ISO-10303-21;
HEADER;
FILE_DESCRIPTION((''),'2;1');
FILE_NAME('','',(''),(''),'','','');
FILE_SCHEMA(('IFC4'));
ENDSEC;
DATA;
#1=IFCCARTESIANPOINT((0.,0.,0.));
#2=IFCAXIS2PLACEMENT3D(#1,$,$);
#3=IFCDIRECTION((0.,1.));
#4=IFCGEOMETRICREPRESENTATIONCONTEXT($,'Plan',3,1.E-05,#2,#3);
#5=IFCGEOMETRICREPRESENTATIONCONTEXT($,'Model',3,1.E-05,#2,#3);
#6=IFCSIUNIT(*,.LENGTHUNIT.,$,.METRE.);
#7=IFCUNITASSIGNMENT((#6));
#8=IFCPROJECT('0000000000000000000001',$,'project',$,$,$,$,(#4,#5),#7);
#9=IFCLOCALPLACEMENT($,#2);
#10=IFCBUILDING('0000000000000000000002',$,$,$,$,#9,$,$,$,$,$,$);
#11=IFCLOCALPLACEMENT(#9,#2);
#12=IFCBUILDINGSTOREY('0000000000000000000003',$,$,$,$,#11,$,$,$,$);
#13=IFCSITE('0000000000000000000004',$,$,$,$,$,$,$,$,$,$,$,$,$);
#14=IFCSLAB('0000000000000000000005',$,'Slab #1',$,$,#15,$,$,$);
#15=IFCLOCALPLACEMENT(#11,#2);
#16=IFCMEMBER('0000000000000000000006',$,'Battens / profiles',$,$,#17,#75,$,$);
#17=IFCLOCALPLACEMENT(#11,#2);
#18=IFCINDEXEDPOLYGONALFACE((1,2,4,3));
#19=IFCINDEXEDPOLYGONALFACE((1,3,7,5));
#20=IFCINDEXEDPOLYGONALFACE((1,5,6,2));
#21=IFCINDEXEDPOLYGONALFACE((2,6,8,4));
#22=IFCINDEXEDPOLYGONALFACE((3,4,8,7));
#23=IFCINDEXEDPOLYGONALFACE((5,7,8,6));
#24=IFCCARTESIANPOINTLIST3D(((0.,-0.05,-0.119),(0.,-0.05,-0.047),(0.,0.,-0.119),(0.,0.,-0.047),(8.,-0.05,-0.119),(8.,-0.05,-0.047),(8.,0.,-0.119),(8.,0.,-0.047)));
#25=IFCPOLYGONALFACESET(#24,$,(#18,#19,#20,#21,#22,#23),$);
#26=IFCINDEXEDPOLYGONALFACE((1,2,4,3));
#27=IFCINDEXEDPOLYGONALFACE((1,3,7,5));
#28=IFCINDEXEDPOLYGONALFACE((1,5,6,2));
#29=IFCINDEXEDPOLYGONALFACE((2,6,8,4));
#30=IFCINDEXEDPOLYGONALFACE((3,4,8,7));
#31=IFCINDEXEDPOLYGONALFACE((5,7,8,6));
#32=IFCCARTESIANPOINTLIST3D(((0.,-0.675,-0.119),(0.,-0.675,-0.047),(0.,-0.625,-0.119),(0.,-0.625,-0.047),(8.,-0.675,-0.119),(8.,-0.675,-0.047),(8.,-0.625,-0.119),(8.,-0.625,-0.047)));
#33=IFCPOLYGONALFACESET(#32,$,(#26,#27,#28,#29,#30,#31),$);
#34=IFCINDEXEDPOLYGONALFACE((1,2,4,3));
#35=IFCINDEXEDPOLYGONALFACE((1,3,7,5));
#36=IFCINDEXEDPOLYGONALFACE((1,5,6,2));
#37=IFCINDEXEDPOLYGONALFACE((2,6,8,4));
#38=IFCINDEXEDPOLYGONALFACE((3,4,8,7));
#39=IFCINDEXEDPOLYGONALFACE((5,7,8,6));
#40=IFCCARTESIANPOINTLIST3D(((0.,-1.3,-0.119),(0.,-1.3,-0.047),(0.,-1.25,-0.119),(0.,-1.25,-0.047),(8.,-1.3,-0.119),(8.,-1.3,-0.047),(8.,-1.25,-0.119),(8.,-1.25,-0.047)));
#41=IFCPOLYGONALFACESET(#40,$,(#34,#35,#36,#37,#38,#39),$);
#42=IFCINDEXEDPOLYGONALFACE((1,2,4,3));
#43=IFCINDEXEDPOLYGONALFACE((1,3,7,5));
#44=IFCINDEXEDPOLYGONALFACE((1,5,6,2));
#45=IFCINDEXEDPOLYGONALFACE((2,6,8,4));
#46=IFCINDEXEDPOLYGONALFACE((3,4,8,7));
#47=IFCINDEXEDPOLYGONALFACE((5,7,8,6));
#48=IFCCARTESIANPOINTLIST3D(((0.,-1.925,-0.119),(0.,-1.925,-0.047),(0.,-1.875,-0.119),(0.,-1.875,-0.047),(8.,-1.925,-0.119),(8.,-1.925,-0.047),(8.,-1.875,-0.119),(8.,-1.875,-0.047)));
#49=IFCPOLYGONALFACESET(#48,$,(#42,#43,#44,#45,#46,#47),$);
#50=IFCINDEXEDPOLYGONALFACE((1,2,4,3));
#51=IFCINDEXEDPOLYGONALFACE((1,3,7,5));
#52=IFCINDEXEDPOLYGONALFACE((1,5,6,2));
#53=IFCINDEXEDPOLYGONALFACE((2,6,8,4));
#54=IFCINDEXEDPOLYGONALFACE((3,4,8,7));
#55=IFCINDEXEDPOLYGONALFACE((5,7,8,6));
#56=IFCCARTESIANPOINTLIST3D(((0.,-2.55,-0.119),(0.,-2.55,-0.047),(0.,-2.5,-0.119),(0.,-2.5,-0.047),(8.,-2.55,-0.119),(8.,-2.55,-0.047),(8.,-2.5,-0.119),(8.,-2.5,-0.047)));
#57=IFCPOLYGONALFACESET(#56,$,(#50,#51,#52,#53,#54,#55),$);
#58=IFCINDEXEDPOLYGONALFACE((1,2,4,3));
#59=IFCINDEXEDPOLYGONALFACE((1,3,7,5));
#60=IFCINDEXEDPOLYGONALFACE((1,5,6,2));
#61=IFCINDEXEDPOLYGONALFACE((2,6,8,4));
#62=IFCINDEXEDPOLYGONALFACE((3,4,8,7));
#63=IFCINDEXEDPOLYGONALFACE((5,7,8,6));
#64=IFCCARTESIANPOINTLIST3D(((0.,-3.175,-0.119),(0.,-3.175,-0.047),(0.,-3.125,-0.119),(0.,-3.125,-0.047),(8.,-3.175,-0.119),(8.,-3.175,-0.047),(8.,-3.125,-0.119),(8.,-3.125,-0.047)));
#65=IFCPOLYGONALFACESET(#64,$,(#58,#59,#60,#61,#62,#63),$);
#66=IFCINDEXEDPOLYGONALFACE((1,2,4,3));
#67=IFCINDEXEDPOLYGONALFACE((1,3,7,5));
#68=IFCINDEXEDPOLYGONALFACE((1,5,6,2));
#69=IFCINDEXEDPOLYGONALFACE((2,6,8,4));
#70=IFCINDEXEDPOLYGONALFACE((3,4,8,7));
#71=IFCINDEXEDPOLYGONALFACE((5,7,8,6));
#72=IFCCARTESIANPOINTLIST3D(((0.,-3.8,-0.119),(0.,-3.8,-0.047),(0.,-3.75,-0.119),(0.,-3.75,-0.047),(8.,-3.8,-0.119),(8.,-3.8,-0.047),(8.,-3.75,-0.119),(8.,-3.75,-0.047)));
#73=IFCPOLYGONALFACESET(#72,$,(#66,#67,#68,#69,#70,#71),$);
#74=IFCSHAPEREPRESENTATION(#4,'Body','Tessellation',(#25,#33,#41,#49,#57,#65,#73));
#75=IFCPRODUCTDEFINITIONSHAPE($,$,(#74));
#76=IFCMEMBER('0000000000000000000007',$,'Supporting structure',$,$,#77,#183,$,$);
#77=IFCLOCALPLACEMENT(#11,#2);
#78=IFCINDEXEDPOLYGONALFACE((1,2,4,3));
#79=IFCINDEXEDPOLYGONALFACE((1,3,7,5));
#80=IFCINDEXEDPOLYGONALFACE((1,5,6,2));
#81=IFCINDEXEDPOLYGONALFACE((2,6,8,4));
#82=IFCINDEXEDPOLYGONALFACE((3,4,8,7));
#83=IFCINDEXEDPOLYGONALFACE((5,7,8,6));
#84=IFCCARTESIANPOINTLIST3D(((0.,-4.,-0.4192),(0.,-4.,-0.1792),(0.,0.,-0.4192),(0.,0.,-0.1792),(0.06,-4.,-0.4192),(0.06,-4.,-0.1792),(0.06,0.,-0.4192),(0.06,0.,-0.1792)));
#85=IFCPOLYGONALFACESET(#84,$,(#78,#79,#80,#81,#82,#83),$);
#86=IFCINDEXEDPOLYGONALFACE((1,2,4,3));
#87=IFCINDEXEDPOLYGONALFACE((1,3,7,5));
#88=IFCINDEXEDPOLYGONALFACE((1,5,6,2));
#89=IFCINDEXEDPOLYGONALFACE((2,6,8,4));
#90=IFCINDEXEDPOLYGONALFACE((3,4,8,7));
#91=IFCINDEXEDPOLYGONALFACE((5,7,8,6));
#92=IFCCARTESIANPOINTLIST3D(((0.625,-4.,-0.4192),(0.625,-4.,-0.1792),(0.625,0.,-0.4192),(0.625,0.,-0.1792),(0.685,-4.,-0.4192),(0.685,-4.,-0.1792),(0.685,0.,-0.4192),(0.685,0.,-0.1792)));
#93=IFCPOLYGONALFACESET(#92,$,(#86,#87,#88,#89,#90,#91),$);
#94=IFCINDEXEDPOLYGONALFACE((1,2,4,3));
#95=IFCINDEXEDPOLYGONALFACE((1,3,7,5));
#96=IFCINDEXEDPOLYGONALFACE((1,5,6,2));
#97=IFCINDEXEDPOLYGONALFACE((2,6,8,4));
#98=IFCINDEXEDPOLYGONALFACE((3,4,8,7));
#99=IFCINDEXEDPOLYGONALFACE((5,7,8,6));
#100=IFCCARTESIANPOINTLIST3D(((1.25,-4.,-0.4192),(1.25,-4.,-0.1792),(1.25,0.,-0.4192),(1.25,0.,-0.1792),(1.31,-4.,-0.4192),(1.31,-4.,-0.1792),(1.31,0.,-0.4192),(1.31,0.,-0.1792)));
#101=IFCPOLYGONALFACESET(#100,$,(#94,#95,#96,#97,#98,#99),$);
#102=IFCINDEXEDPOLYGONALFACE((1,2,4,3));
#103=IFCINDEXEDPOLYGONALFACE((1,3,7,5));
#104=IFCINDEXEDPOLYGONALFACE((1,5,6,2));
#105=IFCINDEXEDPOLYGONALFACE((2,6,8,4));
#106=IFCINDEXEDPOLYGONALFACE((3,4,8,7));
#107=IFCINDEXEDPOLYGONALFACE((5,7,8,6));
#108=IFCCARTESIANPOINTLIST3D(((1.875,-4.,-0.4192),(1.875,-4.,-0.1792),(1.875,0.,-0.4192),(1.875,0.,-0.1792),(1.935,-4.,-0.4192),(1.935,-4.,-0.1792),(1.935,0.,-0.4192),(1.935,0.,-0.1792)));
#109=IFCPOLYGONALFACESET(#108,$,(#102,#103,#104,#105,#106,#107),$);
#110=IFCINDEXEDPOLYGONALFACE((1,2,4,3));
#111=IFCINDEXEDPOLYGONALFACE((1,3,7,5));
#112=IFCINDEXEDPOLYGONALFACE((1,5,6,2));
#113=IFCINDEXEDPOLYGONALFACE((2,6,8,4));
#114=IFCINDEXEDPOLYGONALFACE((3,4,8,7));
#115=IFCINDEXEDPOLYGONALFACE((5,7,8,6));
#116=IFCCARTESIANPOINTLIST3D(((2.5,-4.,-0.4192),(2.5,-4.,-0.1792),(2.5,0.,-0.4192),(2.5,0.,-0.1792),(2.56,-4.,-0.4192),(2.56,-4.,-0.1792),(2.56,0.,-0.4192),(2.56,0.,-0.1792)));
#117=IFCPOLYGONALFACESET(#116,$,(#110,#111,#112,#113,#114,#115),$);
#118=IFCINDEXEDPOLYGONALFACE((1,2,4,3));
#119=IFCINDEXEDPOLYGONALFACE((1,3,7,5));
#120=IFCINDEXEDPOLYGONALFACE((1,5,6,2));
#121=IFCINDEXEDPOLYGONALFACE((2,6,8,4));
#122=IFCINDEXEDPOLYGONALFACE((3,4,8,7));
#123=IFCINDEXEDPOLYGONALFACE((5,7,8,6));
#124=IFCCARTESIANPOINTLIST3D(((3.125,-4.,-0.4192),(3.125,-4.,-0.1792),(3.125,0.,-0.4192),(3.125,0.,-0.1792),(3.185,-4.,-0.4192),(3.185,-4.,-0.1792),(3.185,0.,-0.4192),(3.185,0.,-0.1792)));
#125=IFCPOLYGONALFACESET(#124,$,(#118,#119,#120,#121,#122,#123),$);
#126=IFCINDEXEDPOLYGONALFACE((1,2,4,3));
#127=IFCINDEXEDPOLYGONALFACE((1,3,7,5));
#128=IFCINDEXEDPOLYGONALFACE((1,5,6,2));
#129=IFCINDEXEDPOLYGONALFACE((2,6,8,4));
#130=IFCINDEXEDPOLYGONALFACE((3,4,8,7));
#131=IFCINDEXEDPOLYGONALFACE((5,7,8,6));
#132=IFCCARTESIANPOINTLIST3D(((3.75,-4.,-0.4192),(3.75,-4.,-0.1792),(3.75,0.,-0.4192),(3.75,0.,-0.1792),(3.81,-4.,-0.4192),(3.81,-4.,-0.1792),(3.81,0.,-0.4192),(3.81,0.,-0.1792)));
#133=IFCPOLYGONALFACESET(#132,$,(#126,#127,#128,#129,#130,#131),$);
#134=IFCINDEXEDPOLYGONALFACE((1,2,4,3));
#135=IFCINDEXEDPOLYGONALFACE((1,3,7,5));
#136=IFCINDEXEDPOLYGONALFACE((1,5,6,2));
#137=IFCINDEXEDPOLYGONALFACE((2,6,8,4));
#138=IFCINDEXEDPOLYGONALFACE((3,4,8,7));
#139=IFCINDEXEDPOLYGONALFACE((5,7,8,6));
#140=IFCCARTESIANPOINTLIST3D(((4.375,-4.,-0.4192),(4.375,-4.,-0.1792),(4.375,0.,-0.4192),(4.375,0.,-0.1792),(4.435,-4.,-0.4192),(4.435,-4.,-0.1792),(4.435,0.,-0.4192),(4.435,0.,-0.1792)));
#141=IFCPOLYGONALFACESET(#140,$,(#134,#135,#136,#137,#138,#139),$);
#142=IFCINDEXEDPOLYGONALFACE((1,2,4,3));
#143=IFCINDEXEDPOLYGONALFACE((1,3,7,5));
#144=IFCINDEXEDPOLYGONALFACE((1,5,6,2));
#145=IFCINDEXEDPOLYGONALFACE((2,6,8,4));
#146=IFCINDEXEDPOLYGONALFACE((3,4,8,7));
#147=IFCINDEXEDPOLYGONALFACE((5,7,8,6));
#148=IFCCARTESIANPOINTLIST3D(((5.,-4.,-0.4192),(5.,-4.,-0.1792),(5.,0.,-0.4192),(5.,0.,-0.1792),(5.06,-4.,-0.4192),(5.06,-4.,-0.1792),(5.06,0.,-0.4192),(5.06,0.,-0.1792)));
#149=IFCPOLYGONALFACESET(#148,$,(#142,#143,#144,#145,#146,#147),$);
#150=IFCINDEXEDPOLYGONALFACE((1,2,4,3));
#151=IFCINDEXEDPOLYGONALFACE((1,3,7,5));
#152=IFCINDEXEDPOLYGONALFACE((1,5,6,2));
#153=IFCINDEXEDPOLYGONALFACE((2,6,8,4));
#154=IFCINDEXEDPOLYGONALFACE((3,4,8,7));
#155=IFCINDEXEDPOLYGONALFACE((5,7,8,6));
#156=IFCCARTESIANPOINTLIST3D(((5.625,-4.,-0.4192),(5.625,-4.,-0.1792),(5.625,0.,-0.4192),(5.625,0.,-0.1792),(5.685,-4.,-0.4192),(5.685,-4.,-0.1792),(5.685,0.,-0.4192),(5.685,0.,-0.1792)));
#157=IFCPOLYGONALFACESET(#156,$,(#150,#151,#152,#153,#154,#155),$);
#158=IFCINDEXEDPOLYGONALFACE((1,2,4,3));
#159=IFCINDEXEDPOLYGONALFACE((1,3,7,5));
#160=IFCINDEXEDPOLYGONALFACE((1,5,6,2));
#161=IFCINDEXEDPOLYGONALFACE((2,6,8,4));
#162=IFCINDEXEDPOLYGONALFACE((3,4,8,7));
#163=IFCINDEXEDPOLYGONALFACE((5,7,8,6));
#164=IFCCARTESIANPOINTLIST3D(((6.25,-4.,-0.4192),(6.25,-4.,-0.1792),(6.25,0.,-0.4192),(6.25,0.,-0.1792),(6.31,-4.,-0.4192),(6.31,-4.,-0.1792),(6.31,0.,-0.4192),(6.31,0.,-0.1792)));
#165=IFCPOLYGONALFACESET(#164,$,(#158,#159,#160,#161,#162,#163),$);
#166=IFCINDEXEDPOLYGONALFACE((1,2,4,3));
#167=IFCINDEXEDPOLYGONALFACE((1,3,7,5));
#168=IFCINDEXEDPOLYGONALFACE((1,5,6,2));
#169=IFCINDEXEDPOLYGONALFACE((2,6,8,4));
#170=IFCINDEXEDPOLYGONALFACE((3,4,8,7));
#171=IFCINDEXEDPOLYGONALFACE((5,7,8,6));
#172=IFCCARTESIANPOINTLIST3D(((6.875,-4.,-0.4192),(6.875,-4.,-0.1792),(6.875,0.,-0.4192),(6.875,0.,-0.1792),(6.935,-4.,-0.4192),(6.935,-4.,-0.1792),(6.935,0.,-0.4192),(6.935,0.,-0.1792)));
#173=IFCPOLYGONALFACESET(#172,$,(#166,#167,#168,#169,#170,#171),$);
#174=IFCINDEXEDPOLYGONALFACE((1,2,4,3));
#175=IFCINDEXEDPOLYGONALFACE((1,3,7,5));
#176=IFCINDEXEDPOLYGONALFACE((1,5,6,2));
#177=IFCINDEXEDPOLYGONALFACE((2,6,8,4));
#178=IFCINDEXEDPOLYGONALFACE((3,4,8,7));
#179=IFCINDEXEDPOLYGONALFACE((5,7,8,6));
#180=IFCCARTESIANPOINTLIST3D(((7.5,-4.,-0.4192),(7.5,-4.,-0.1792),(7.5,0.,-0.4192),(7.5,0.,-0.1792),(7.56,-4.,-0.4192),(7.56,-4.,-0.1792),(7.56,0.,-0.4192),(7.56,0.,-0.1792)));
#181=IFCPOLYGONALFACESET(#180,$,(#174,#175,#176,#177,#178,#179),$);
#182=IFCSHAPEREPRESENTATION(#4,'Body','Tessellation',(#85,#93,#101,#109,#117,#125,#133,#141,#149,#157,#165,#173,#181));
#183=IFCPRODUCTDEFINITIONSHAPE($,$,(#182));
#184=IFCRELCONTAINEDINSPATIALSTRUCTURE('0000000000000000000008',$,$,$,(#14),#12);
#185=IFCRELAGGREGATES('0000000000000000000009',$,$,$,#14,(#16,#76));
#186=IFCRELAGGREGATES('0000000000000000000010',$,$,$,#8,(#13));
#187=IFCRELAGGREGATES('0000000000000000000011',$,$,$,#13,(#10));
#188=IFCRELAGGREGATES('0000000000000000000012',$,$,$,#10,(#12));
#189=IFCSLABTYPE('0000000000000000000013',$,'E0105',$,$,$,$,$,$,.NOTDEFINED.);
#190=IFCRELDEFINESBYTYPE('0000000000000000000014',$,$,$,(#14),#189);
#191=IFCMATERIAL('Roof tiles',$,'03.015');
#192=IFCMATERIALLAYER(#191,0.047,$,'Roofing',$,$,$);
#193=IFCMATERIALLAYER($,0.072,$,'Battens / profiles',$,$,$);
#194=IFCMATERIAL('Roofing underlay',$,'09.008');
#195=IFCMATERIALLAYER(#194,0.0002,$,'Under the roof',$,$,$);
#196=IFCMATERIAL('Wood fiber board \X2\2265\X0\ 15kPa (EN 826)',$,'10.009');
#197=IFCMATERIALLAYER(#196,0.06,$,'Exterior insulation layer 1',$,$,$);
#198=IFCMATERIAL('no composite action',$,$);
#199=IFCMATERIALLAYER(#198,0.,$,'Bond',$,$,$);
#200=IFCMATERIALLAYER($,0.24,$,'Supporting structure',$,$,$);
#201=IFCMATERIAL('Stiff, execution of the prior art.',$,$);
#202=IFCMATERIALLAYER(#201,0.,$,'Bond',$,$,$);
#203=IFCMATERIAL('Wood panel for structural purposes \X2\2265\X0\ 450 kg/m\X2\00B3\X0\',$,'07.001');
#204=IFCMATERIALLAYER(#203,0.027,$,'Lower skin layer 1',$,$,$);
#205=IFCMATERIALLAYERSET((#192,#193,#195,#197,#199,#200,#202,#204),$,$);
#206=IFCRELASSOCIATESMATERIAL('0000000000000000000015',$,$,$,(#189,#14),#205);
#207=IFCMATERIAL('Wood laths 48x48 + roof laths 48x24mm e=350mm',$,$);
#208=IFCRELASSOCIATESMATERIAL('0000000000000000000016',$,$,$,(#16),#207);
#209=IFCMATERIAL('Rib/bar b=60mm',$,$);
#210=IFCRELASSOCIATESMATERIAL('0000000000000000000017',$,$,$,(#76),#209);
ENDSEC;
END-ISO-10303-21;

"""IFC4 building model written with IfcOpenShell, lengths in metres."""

from ifc_helpers import new_model, si_unit, direction, frame, frame_2d, origin, place, context, project, spatial, rectangle, extrude, material, layer, layer_set, type_object, element, aggregate, save


model = new_model("IFC4")

# Units and contexts
plan_context = context("Plan", 3, precision=1e-05, world=origin(), true_north=direction((0.0, 1.0)))
model_context = context("Model", 3, precision=1e-05, world=origin(), true_north=direction((0.0, 1.0)))
ifc_project = project(units=[si_unit("LENGTHUNIT", "METRE")], contexts=[plan_context, model_context])

# Site, building, storey
site = spatial("IfcSite", under=ifc_project)
building_placement = place(None, origin())
building = spatial("IfcBuilding", under=site, at=building_placement)
storey_placement = place(building_placement, origin())
storey = spatial("IfcBuildingStorey", under=building, at=storey_placement)

# Slab, members
ifc_material_1 = material(Name="Roof tiles", Category="03.015")
ifc_layer_1 = layer(ifc_material_1, 0.047, Name="Roofing")
ifc_layer_2 = layer(None, 0.072, Name="Battens / profiles")
ifc_material_2 = material(Name="Roofing underlay", Category="09.008")
ifc_layer_3 = layer(ifc_material_2, 0.0002, Name="Under the roof")
ifc_material_3 = material(Name="Wood fiber board ≥ 15kPa (EN 826)", Category="10.009")
ifc_layer_4 = layer(ifc_material_3, 0.06, Name="Exterior insulation layer 1")
ifc_material_4 = material(Name="no composite action")
ifc_layer_5 = layer(ifc_material_4, 0.0, Name="Bond")
ifc_layer_6 = layer(None, 0.24, Name="Supporting structure")
ifc_material_5 = material(Name="Stiff, execution of the prior art.")
ifc_layer_7 = layer(ifc_material_5, 0.0, Name="Bond")
ifc_material_6 = material(Name="Wood panel for structural purposes ≥ 450 kg/m³", Category="07.001")
ifc_layer_8 = layer(ifc_material_6, 0.027, Name="Lower skin layer 1")
ifc_layer_set = layer_set([ifc_layer_1, ifc_layer_2, ifc_layer_3, ifc_layer_4, ifc_layer_5, ifc_layer_6, ifc_layer_7, ifc_layer_8])
slab_type = type_object("IfcSlabType", Name="E0105", PredefinedType="NOTDEFINED", material=ifc_layer_set)
slab_placement = place(None, frame((0.0, 0.0, 0.0), z_axis=(0.0, 0.0, -1.0), x_axis=(1.0, 0.0, 0.0)))
slab = element("IfcSlab", 1, at=slab_placement, inside=storey, type_object=slab_type, material=ifc_layer_set, Name="Slab #1")
ifc_material_7 = material(Name="Wood laths 48x48 + roof laths 48x24mm e=350mm")
member_1_placement = place(slab_placement, origin())
member_1 = element("IfcMember", 2, at=member_1_placement, material=ifc_material_7, Name="Battens / profiles", context=plan_context, shape_type="SweptSolid", body=[
    extrude(rectangle(XDim=0.05, YDim=0.072, at=frame_2d((0.025, 0.036), x_axis=(1.0, 0.0))), frame((0.0, 0.0, 0.047), z_axis=(1.0, 0.0, 0.0), x_axis=(0.0, 1.0, 0.0)), (0.0, 0.0, 1.0), 8.0),
    extrude(rectangle(XDim=0.05, YDim=0.072, at=frame_2d((0.025, 0.036), x_axis=(1.0, 0.0))), frame((0.0, 0.625, 0.047), z_axis=(1.0, 0.0, 0.0), x_axis=(0.0, 1.0, 0.0)), (0.0, 0.0, 1.0), 8.0),
    extrude(rectangle(XDim=0.05, YDim=0.072, at=frame_2d((0.025, 0.036), x_axis=(1.0, 0.0))), frame((0.0, 1.25, 0.047), z_axis=(1.0, 0.0, 0.0), x_axis=(0.0, 1.0, 0.0)), (0.0, 0.0, 1.0), 8.0),
    extrude(rectangle(XDim=0.05, YDim=0.072, at=frame_2d((0.025, 0.036), x_axis=(1.0, 0.0))), frame((0.0, 1.875, 0.047), z_axis=(1.0, 0.0, 0.0), x_axis=(0.0, 1.0, 0.0)), (0.0, 0.0, 1.0), 8.0),
    extrude(rectangle(XDim=0.05, YDim=0.072, at=frame_2d((0.025, 0.036), x_axis=(1.0, 0.0))), frame((0.0, 2.5, 0.047), z_axis=(1.0, 0.0, 0.0), x_axis=(0.0, 1.0, 0.0)), (0.0, 0.0, 1.0), 8.0),
    extrude(rectangle(XDim=0.05, YDim=0.072, at=frame_2d((0.025, 0.036), x_axis=(1.0, 0.0))), frame((0.0, 3.125, 0.047), z_axis=(1.0, 0.0, 0.0), x_axis=(0.0, 1.0, 0.0)), (0.0, 0.0, 1.0), 8.0),
    extrude(rectangle(XDim=0.05, YDim=0.072, at=frame_2d((0.025, 0.036), x_axis=(1.0, 0.0))), frame((0.0, 3.75, 0.047), z_axis=(1.0, 0.0, 0.0), x_axis=(0.0, 1.0, 0.0)), (0.0, 0.0, 1.0), 8.0),
])
ifc_material_8 = material(Name="Rib/bar b=60mm")
member_2_placement = place(slab_placement, origin())
member_2 = element("IfcMember", 3, at=member_2_placement, material=ifc_material_8, Name="Supporting structure", context=plan_context, shape_type="SweptSolid", body=[
    extrude(rectangle(XDim=0.06, YDim=0.24, at=frame_2d((0.03, 0.12), x_axis=(1.0, 0.0))), frame((0.0, 4.0, 0.1792), z_axis=(0.0, -1.0, 0.0), x_axis=(1.0, 0.0, 0.0)), (0.0, 0.0, 1.0), 4.0),
    extrude(rectangle(XDim=0.06, YDim=0.24, at=frame_2d((0.03, 0.12), x_axis=(1.0, 0.0))), frame((0.625, 4.0, 0.1792), z_axis=(0.0, -1.0, 0.0), x_axis=(1.0, 0.0, 0.0)), (0.0, 0.0, 1.0), 4.0),
    extrude(rectangle(XDim=0.06, YDim=0.24, at=frame_2d((0.03, 0.12), x_axis=(1.0, 0.0))), frame((1.25, 4.0, 0.1792), z_axis=(0.0, -1.0, 0.0), x_axis=(1.0, 0.0, 0.0)), (0.0, 0.0, 1.0), 4.0),
    extrude(rectangle(XDim=0.06, YDim=0.24, at=frame_2d((0.03, 0.12), x_axis=(1.0, 0.0))), frame((1.875, 4.0, 0.1792), z_axis=(0.0, -1.0, 0.0), x_axis=(1.0, 0.0, 0.0)), (0.0, 0.0, 1.0), 4.0),
    extrude(rectangle(XDim=0.06, YDim=0.24, at=frame_2d((0.03, 0.12), x_axis=(1.0, 0.0))), frame((2.5, 4.0, 0.1792), z_axis=(0.0, -1.0, 0.0), x_axis=(1.0, 0.0, 0.0)), (0.0, 0.0, 1.0), 4.0),
    extrude(rectangle(XDim=0.06, YDim=0.24, at=frame_2d((0.03, 0.12), x_axis=(1.0, 0.0))), frame((3.125, 4.0, 0.1792), z_axis=(0.0, -1.0, 0.0), x_axis=(1.0, 0.0, 0.0)), (0.0, 0.0, 1.0), 4.0),
    extrude(rectangle(XDim=0.06, YDim=0.24, at=frame_2d((0.03, 0.12), x_axis=(1.0, 0.0))), frame((3.75, 4.0, 0.1792), z_axis=(0.0, -1.0, 0.0), x_axis=(1.0, 0.0, 0.0)), (0.0, 0.0, 1.0), 4.0),
    extrude(rectangle(XDim=0.06, YDim=0.24, at=frame_2d((0.03, 0.12), x_axis=(1.0, 0.0))), frame((4.375, 4.0, 0.1792), z_axis=(0.0, -1.0, 0.0), x_axis=(1.0, 0.0, 0.0)), (0.0, 0.0, 1.0), 4.0),
    extrude(rectangle(XDim=0.06, YDim=0.24, at=frame_2d((0.03, 0.12), x_axis=(1.0, 0.0))), frame((5.0, 4.0, 0.1792), z_axis=(0.0, -1.0, 0.0), x_axis=(1.0, 0.0, 0.0)), (0.0, 0.0, 1.0), 4.0),
    extrude(rectangle(XDim=0.06, YDim=0.24, at=frame_2d((0.03, 0.12), x_axis=(1.0, 0.0))), frame((5.625, 4.0, 0.1792), z_axis=(0.0, -1.0, 0.0), x_axis=(1.0, 0.0, 0.0)), (0.0, 0.0, 1.0), 4.0),
    extrude(rectangle(XDim=0.06, YDim=0.24, at=frame_2d((0.03, 0.12), x_axis=(1.0, 0.0))), frame((6.25, 4.0, 0.1792), z_axis=(0.0, -1.0, 0.0), x_axis=(1.0, 0.0, 0.0)), (0.0, 0.0, 1.0), 4.0),
    extrude(rectangle(XDim=0.06, YDim=0.24, at=frame_2d((0.03, 0.12), x_axis=(1.0, 0.0))), frame((6.875, 4.0, 0.1792), z_axis=(0.0, -1.0, 0.0), x_axis=(1.0, 0.0, 0.0)), (0.0, 0.0, 1.0), 4.0),
    extrude(rectangle(XDim=0.06, YDim=0.24, at=frame_2d((0.03, 0.12), x_axis=(1.0, 0.0))), frame((7.5, 4.0, 0.1792), z_axis=(0.0, -1.0, 0.0), x_axis=(1.0, 0.0, 0.0)), (0.0, 0.0, 1.0), 4.0),
])
aggregate(slab, [member_1, member_2])

save(model, "model.ifc")
